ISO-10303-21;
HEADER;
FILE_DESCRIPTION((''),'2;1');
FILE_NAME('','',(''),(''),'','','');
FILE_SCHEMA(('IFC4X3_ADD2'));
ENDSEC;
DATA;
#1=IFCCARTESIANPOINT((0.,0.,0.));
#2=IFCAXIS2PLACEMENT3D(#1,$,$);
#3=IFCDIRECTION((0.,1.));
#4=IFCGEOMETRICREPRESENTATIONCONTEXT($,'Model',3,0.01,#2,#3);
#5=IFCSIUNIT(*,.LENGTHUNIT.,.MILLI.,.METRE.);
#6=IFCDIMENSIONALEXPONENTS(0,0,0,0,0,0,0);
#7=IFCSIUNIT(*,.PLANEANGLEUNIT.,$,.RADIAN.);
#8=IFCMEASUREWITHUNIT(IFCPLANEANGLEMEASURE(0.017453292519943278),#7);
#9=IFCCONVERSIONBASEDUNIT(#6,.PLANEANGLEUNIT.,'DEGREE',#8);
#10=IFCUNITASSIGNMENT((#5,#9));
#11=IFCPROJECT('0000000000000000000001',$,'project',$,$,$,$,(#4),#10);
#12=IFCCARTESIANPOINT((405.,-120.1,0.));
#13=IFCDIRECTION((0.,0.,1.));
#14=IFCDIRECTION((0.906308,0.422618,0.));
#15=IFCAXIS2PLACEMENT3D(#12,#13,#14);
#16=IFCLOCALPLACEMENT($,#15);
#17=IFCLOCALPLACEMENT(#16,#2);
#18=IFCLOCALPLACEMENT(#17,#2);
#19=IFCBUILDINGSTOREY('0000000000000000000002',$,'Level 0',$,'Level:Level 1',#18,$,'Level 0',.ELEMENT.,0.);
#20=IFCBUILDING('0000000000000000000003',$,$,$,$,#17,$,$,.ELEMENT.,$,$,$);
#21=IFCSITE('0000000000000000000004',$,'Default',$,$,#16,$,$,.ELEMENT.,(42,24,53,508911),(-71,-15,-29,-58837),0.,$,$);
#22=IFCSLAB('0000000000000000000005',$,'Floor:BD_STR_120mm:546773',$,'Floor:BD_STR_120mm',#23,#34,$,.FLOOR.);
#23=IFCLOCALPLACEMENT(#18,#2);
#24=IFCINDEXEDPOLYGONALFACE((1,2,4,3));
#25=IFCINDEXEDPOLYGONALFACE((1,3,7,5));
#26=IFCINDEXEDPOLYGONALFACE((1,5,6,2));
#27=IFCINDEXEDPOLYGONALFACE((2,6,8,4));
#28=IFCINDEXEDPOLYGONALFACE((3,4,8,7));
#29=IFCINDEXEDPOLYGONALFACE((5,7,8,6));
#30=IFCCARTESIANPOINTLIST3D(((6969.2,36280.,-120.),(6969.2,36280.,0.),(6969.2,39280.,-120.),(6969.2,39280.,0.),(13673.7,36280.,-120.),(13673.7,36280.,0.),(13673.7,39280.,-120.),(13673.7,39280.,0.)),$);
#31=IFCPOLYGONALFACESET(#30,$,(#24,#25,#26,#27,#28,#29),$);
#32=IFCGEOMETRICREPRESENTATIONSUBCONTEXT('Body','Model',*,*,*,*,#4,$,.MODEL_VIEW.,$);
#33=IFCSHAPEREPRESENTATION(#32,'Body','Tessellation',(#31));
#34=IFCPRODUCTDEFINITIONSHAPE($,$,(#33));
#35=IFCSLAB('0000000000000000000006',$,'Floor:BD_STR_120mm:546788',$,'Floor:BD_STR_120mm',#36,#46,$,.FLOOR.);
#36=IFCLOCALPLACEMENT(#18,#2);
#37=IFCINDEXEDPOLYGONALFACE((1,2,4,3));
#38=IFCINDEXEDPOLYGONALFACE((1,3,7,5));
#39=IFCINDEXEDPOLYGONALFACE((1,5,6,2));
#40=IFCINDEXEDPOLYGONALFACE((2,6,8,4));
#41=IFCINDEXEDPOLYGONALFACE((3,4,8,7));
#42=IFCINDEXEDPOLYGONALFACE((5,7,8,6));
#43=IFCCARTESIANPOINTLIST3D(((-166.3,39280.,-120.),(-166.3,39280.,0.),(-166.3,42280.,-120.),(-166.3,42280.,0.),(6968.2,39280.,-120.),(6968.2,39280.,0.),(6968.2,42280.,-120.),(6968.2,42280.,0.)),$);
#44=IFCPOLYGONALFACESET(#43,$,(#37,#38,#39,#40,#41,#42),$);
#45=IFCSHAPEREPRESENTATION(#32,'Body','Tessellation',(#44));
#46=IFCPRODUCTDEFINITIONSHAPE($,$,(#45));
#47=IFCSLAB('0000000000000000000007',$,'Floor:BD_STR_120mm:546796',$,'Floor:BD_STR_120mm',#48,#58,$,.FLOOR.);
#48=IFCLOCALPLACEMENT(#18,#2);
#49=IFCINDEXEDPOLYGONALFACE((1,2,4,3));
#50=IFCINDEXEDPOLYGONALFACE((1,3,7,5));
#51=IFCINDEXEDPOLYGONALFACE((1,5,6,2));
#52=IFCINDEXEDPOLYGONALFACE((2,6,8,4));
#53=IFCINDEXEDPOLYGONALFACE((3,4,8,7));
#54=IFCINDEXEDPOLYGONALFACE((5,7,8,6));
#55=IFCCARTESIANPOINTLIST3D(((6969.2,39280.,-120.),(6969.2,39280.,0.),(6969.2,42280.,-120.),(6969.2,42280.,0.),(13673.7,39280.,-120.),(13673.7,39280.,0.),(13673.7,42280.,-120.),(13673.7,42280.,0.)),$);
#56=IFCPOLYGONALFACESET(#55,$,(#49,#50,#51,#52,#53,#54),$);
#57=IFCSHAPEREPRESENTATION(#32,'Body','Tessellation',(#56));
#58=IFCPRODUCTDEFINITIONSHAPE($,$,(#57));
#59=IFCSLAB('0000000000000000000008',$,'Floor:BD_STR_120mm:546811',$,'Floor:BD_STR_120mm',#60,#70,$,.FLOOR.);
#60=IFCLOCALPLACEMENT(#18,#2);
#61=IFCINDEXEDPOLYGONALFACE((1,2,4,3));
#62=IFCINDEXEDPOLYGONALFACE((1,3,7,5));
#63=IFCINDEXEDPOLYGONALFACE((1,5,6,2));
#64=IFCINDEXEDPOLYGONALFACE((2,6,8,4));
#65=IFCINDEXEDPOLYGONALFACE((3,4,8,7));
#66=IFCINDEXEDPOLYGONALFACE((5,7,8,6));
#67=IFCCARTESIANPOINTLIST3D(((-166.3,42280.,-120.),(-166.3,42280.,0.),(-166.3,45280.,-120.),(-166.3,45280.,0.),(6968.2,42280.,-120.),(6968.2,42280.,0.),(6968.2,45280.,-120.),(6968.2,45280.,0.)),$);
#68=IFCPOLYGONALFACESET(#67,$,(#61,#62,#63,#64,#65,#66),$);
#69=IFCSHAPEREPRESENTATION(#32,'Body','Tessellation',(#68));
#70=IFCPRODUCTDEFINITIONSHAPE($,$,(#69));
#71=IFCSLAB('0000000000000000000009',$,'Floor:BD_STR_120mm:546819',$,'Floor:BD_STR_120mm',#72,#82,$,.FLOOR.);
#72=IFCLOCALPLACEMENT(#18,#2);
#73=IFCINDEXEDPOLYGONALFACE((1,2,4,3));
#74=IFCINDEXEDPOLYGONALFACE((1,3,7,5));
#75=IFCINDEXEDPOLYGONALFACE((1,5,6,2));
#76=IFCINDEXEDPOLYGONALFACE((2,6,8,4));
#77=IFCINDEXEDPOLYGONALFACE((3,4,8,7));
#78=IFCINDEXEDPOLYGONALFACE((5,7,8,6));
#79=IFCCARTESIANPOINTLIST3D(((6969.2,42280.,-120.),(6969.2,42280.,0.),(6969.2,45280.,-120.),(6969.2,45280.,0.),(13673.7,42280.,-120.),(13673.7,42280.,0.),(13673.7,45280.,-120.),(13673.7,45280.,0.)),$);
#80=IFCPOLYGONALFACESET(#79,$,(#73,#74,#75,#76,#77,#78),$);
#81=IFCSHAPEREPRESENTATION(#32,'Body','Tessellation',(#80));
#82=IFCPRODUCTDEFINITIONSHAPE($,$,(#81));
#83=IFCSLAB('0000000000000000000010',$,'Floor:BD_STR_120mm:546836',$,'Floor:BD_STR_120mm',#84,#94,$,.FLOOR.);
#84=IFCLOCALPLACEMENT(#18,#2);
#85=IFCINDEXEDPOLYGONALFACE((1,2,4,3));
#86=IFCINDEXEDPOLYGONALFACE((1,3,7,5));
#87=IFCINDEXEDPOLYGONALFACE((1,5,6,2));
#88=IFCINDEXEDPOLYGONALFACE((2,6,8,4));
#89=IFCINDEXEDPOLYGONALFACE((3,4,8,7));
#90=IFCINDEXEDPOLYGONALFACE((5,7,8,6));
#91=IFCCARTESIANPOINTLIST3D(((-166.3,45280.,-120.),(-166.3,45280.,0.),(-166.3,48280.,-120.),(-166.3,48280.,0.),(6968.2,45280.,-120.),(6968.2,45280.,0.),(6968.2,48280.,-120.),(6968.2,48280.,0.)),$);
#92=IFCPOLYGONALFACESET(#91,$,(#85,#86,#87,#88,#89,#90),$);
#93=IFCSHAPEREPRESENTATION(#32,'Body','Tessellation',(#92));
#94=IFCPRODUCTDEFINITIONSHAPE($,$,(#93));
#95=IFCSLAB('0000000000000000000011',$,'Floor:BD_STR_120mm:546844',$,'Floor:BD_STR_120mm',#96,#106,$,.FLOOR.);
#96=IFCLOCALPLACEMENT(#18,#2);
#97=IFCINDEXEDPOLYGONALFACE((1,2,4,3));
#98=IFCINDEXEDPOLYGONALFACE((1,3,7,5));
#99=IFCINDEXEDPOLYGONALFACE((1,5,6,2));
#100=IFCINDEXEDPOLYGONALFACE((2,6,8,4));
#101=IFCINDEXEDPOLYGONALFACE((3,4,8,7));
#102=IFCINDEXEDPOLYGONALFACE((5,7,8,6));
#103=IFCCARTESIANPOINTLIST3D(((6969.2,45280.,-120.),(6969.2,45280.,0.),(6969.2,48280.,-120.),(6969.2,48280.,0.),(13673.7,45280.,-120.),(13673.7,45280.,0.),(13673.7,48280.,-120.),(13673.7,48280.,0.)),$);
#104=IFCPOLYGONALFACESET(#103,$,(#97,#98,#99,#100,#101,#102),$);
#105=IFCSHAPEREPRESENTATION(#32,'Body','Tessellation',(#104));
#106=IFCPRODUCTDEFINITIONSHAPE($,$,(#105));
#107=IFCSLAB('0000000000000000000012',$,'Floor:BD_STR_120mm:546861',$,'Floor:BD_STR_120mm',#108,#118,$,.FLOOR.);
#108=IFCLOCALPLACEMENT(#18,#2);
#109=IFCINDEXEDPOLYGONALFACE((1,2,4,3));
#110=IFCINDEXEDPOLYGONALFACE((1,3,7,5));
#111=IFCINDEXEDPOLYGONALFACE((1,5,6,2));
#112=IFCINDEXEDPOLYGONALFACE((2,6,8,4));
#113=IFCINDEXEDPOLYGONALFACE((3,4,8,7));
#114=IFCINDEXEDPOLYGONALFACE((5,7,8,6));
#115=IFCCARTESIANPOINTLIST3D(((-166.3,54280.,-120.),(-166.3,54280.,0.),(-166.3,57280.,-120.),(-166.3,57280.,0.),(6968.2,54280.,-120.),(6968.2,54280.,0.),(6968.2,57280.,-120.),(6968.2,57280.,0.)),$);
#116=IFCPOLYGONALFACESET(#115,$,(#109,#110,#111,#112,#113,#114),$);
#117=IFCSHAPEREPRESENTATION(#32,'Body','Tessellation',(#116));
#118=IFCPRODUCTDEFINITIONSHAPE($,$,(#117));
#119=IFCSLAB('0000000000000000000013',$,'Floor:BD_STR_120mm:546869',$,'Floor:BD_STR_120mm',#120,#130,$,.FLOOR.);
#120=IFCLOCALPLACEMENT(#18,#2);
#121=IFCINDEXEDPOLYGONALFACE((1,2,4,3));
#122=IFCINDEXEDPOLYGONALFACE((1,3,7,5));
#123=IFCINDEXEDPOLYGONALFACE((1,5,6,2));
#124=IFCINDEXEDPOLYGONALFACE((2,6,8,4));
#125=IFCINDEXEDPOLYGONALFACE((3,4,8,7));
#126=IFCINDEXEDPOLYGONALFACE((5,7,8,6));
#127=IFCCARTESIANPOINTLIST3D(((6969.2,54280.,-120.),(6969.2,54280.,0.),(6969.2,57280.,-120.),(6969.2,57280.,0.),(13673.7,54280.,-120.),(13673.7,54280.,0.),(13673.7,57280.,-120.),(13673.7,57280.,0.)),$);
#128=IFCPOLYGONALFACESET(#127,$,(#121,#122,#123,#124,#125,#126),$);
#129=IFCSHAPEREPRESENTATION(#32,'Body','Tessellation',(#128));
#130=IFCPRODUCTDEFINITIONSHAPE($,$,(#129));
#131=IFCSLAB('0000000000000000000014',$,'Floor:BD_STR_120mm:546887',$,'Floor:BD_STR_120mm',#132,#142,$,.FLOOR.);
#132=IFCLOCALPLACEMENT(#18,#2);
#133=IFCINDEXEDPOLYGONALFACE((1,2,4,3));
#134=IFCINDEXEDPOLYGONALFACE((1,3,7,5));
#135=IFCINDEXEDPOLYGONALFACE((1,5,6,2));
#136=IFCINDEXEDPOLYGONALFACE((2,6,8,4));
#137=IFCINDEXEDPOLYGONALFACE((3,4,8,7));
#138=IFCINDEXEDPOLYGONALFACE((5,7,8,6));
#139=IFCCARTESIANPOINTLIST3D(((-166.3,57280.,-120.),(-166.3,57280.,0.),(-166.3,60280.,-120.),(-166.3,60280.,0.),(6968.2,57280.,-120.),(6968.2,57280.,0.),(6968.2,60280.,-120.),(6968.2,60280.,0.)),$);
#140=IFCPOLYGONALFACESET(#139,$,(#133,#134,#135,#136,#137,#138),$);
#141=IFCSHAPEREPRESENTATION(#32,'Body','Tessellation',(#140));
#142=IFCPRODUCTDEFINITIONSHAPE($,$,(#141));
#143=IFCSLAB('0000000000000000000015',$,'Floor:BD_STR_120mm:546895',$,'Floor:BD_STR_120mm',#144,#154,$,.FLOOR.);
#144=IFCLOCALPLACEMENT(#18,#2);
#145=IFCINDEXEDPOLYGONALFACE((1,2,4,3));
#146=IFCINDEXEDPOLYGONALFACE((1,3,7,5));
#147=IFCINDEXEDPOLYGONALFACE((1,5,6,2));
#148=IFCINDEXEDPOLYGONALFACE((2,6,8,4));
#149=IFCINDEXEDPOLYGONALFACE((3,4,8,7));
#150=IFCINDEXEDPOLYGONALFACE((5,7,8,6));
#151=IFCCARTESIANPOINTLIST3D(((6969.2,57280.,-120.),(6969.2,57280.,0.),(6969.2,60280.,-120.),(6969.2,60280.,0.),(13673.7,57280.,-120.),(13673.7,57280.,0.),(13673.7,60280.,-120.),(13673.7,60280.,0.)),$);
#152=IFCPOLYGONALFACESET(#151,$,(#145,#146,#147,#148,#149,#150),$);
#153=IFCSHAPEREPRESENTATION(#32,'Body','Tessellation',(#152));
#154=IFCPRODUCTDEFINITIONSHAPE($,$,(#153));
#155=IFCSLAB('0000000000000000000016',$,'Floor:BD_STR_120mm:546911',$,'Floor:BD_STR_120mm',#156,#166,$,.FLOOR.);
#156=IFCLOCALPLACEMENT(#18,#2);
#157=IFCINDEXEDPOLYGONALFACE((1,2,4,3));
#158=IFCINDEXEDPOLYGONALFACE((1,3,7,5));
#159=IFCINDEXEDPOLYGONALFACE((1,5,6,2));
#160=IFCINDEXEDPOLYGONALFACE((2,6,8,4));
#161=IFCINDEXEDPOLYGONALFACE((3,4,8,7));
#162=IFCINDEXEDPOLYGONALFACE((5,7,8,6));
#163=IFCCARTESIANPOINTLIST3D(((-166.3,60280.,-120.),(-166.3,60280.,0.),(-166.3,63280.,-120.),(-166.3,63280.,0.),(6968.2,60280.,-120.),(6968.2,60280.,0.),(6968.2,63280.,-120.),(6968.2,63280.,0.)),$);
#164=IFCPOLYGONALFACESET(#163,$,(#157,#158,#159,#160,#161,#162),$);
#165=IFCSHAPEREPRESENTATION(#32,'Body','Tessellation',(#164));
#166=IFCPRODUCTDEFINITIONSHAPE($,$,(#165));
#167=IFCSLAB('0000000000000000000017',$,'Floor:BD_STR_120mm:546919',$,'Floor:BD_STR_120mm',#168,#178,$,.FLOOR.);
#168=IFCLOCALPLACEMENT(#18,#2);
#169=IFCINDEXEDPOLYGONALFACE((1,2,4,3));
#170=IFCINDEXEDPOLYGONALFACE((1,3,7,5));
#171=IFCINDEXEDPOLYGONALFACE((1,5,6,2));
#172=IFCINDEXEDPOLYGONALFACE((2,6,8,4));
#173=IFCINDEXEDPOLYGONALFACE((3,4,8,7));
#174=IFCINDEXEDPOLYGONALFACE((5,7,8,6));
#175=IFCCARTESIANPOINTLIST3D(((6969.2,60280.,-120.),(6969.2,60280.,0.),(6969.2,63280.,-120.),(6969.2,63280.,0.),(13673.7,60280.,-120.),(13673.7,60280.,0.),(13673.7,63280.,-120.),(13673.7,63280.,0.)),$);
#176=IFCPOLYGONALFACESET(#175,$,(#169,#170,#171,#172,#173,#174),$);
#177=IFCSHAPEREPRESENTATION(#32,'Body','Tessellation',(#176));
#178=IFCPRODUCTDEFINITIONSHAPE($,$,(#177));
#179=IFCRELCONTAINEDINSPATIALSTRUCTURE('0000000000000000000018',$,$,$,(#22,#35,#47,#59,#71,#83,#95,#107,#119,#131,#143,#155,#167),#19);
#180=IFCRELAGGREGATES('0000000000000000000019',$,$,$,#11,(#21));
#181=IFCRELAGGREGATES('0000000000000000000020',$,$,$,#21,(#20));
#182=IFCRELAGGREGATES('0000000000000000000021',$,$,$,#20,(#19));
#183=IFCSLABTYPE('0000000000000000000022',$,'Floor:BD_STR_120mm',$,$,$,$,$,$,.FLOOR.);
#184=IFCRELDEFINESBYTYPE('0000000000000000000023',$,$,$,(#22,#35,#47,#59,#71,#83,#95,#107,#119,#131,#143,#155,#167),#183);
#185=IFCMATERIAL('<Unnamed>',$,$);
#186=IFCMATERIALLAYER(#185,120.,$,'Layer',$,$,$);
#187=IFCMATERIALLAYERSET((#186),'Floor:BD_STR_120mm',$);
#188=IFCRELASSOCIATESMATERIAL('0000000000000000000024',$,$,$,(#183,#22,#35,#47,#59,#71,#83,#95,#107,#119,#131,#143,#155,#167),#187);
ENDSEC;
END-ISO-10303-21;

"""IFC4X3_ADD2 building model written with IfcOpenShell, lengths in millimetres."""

from ifc_helpers import new_model, entity, si_unit, converted_unit, direction, frame, frame_2d, origin, place, context, subcontext, project, spatial, rectangle, extrude, material, layer, layer_set, layer_usage, type_object, element, save


model = new_model("IFC4X3_ADD2")

# Units and contexts
model_context = context("Model", 3, precision=0.01, world=origin(), true_north=direction((0.0, 1.0)))
body_context = subcontext(model_context, "Body", "Model", "MODEL_VIEW")
ifc_project = project(units=[si_unit("LENGTHUNIT", "METRE", prefix="MILLI"), converted_unit("PLANEANGLEUNIT", "DEGREE", entity("IfcPlaneAngleMeasure", 0.017453292519943278), si_unit("PLANEANGLEUNIT", "RADIAN"), dimensions=[0, 0, 0, 0, 0, 0, 0])], contexts=[model_context])

# Site, building, storey
site_placement = place(None, frame((405.0, -120.1, 0.0), z_axis=(0.0, 0.0, 1.0), x_axis=(0.906308, 0.422618, 0.0)))
site = spatial("IfcSite", under=ifc_project, at=site_placement, Name="Default", CompositionType="ELEMENT", RefLatitude=(42, 24, 53, 508911), RefLongitude=(-71, -15, -29, -58837), RefElevation=0.0)
building_placement = place(site_placement, origin())
building = spatial("IfcBuilding", under=site, at=building_placement, CompositionType="ELEMENT")
storey_placement = place(building_placement, origin())
storey = spatial("IfcBuildingStorey", under=building, at=storey_placement, Name="Level 0", ObjectType="Level:Level 1", LongName="Level 0", CompositionType="ELEMENT", Elevation=0.0)

# Slabs
ifc_material = material(Name="<Unnamed>")
ifc_layer = layer(ifc_material, 120.0, Name="Layer")
ifc_layer_set = layer_set([ifc_layer], Name="Floor:BD_STR_120mm")
slab_type = type_object("IfcSlabType", Name="Floor:BD_STR_120mm", PredefinedType="FLOOR", material=ifc_layer_set)
ifc_layer_usage_1 = layer_usage(ifc_layer_set, "AXIS3", "POSITIVE", 0.0)
slab_1_placement = place(storey_placement, origin())
element("IfcSlab", 1, at=slab_1_placement, inside=storey, type_object=slab_type, material=ifc_layer_usage_1, Name="Floor:BD_STR_120mm:546773", ObjectType="Floor:BD_STR_120mm", PredefinedType="FLOOR", context=body_context, shape_type="SweptSolid", body=[
    extrude(rectangle(XDim=3000.0, YDim=6704.5, at=frame_2d((0.0, 0.0), x_axis=(1.0, 0.0))), frame((10321.5, 37780.0, 0.0), z_axis=(0.0, 0.0, -1.0), x_axis=(0.0, 1.0, 0.0)), (0.0, 0.0, 1.0), 120.0),
])
ifc_layer_usage_2 = layer_usage(ifc_layer_set, "AXIS3", "POSITIVE", 0.0)
slab_2_placement = place(storey_placement, origin())
element("IfcSlab", 2, at=slab_2_placement, inside=storey, type_object=slab_type, material=ifc_layer_usage_2, Name="Floor:BD_STR_120mm:546788", ObjectType="Floor:BD_STR_120mm", PredefinedType="FLOOR", context=body_context, shape_type="SweptSolid", body=[
    extrude(rectangle(XDim=3000.0, YDim=7134.5, at=frame_2d((0.0, 0.0), x_axis=(1.0, 0.0))), frame((3401.0, 40780.0, 0.0), z_axis=(0.0, 0.0, -1.0), x_axis=(0.0, 1.0, 0.0)), (0.0, 0.0, 1.0), 120.0),
])
ifc_layer_usage_3 = layer_usage(ifc_layer_set, "AXIS3", "POSITIVE", 0.0)
slab_3_placement = place(storey_placement, origin())
element("IfcSlab", 3, at=slab_3_placement, inside=storey, type_object=slab_type, material=ifc_layer_usage_3, Name="Floor:BD_STR_120mm:546796", ObjectType="Floor:BD_STR_120mm", PredefinedType="FLOOR", context=body_context, shape_type="SweptSolid", body=[
    extrude(rectangle(XDim=3000.0, YDim=6704.5, at=frame_2d((0.0, 0.0), x_axis=(1.0, 0.0))), frame((10321.5, 40780.0, 0.0), z_axis=(0.0, 0.0, -1.0), x_axis=(0.0, 1.0, 0.0)), (0.0, 0.0, 1.0), 120.0),
])
ifc_layer_usage_4 = layer_usage(ifc_layer_set, "AXIS3", "POSITIVE", 0.0)
slab_4_placement = place(storey_placement, origin())
element("IfcSlab", 4, at=slab_4_placement, inside=storey, type_object=slab_type, material=ifc_layer_usage_4, Name="Floor:BD_STR_120mm:546811", ObjectType="Floor:BD_STR_120mm", PredefinedType="FLOOR", context=body_context, shape_type="SweptSolid", body=[
    extrude(rectangle(XDim=3000.0, YDim=7134.5, at=frame_2d((0.0, 0.0), x_axis=(1.0, 0.0))), frame((3401.0, 43780.0, 0.0), z_axis=(0.0, 0.0, -1.0), x_axis=(0.0, 1.0, 0.0)), (0.0, 0.0, 1.0), 120.0),
])
ifc_layer_usage_5 = layer_usage(ifc_layer_set, "AXIS3", "POSITIVE", 0.0)
slab_5_placement = place(storey_placement, origin())
element("IfcSlab", 5, at=slab_5_placement, inside=storey, type_object=slab_type, material=ifc_layer_usage_5, Name="Floor:BD_STR_120mm:546819", ObjectType="Floor:BD_STR_120mm", PredefinedType="FLOOR", context=body_context, shape_type="SweptSolid", body=[
    extrude(rectangle(XDim=3000.0, YDim=6704.5, at=frame_2d((0.0, 0.0), x_axis=(1.0, 0.0))), frame((10321.5, 43780.0, 0.0), z_axis=(0.0, 0.0, -1.0), x_axis=(0.0, 1.0, 0.0)), (0.0, 0.0, 1.0), 120.0),
])
ifc_layer_usage_6 = layer_usage(ifc_layer_set, "AXIS3", "POSITIVE", 0.0)
slab_6_placement = place(storey_placement, origin())
element("IfcSlab", 6, at=slab_6_placement, inside=storey, type_object=slab_type, material=ifc_layer_usage_6, Name="Floor:BD_STR_120mm:546836", ObjectType="Floor:BD_STR_120mm", PredefinedType="FLOOR", context=body_context, shape_type="SweptSolid", body=[
    extrude(rectangle(XDim=3000.0, YDim=7134.5, at=frame_2d((0.0, 0.0), x_axis=(1.0, 0.0))), frame((3401.0, 46780.0, 0.0), z_axis=(0.0, 0.0, -1.0), x_axis=(0.0, 1.0, 0.0)), (0.0, 0.0, 1.0), 120.0),
])
ifc_layer_usage_7 = layer_usage(ifc_layer_set, "AXIS3", "POSITIVE", 0.0)
slab_7_placement = place(storey_placement, origin())
element("IfcSlab", 7, at=slab_7_placement, inside=storey, type_object=slab_type, material=ifc_layer_usage_7, Name="Floor:BD_STR_120mm:546844", ObjectType="Floor:BD_STR_120mm", PredefinedType="FLOOR", context=body_context, shape_type="SweptSolid", body=[
    extrude(rectangle(XDim=3000.0, YDim=6704.5, at=frame_2d((0.0, 0.0), x_axis=(1.0, 0.0))), frame((10321.5, 46780.0, 0.0), z_axis=(0.0, 0.0, -1.0), x_axis=(0.0, 1.0, 0.0)), (0.0, 0.0, 1.0), 120.0),
])
ifc_layer_usage_8 = layer_usage(ifc_layer_set, "AXIS3", "POSITIVE", 0.0)
slab_8_placement = place(storey_placement, origin())
element("IfcSlab", 8, at=slab_8_placement, inside=storey, type_object=slab_type, material=ifc_layer_usage_8, Name="Floor:BD_STR_120mm:546861", ObjectType="Floor:BD_STR_120mm", PredefinedType="FLOOR", context=body_context, shape_type="SweptSolid", body=[
    extrude(rectangle(XDim=3000.0, YDim=7134.5, at=frame_2d((0.0, 0.0), x_axis=(1.0, 0.0))), frame((3401.0, 55780.0, 0.0), z_axis=(0.0, 0.0, -1.0), x_axis=(0.0, 1.0, 0.0)), (0.0, 0.0, 1.0), 120.0),
])
ifc_layer_usage_9 = layer_usage(ifc_layer_set, "AXIS3", "POSITIVE", 0.0)
slab_9_placement = place(storey_placement, origin())
element("IfcSlab", 9, at=slab_9_placement, inside=storey, type_object=slab_type, material=ifc_layer_usage_9, Name="Floor:BD_STR_120mm:546869", ObjectType="Floor:BD_STR_120mm", PredefinedType="FLOOR", context=body_context, shape_type="SweptSolid", body=[
    extrude(rectangle(XDim=3000.0, YDim=6704.5, at=frame_2d((0.0, 0.0), x_axis=(1.0, 0.0))), frame((10321.5, 55780.0, 0.0), z_axis=(0.0, 0.0, -1.0), x_axis=(0.0, 1.0, 0.0)), (0.0, 0.0, 1.0), 120.0),
])
ifc_layer_usage_10 = layer_usage(ifc_layer_set, "AXIS3", "POSITIVE", 0.0)
slab_10_placement = place(storey_placement, origin())
element("IfcSlab", 10, at=slab_10_placement, inside=storey, type_object=slab_type, material=ifc_layer_usage_10, Name="Floor:BD_STR_120mm:546887", ObjectType="Floor:BD_STR_120mm", PredefinedType="FLOOR", context=body_context, shape_type="SweptSolid", body=[
    extrude(rectangle(XDim=3000.0, YDim=7134.5, at=frame_2d((0.0, 0.0), x_axis=(1.0, 0.0))), frame((3401.0, 58780.0, 0.0), z_axis=(0.0, 0.0, -1.0), x_axis=(0.0, 1.0, 0.0)), (0.0, 0.0, 1.0), 120.0),
])
ifc_layer_usage_11 = layer_usage(ifc_layer_set, "AXIS3", "POSITIVE", 0.0)
slab_11_placement = place(storey_placement, origin())
element("IfcSlab", 11, at=slab_11_placement, inside=storey, type_object=slab_type, material=ifc_layer_usage_11, Name="Floor:BD_STR_120mm:546895", ObjectType="Floor:BD_STR_120mm", PredefinedType="FLOOR", context=body_context, shape_type="SweptSolid", body=[
    extrude(rectangle(XDim=3000.0, YDim=6704.5, at=frame_2d((0.0, 0.0), x_axis=(1.0, 0.0))), frame((10321.5, 58780.0, 0.0), z_axis=(0.0, 0.0, -1.0), x_axis=(0.0, 1.0, 0.0)), (0.0, 0.0, 1.0), 120.0),
])
ifc_layer_usage_12 = layer_usage(ifc_layer_set, "AXIS3", "POSITIVE", 0.0)
slab_12_placement = place(storey_placement, origin())
element("IfcSlab", 12, at=slab_12_placement, inside=storey, type_object=slab_type, material=ifc_layer_usage_12, Name="Floor:BD_STR_120mm:546911", ObjectType="Floor:BD_STR_120mm", PredefinedType="FLOOR", context=body_context, shape_type="SweptSolid", body=[
    extrude(rectangle(XDim=3000.0, YDim=7134.5, at=frame_2d((0.0, 0.0), x_axis=(1.0, 0.0))), frame((3401.0, 61780.0, 0.0), z_axis=(0.0, 0.0, -1.0), x_axis=(0.0, 1.0, 0.0)), (0.0, 0.0, 1.0), 120.0),
])
ifc_layer_usage_13 = layer_usage(ifc_layer_set, "AXIS3", "POSITIVE", 0.0)
slab_13_placement = place(storey_placement, origin())
element("IfcSlab", 13, at=slab_13_placement, inside=storey, type_object=slab_type, material=ifc_layer_usage_13, Name="Floor:BD_STR_120mm:546919", ObjectType="Floor:BD_STR_120mm", PredefinedType="FLOOR", context=body_context, shape_type="SweptSolid", body=[
    extrude(rectangle(XDim=3000.0, YDim=6704.5, at=frame_2d((0.0, 0.0), x_axis=(1.0, 0.0))), frame((10321.5, 61780.0, 0.0), z_axis=(0.0, 0.0, -1.0), x_axis=(0.0, 1.0, 0.0)), (0.0, 0.0, 1.0), 120.0),
])

save(model, "model.ifc")
